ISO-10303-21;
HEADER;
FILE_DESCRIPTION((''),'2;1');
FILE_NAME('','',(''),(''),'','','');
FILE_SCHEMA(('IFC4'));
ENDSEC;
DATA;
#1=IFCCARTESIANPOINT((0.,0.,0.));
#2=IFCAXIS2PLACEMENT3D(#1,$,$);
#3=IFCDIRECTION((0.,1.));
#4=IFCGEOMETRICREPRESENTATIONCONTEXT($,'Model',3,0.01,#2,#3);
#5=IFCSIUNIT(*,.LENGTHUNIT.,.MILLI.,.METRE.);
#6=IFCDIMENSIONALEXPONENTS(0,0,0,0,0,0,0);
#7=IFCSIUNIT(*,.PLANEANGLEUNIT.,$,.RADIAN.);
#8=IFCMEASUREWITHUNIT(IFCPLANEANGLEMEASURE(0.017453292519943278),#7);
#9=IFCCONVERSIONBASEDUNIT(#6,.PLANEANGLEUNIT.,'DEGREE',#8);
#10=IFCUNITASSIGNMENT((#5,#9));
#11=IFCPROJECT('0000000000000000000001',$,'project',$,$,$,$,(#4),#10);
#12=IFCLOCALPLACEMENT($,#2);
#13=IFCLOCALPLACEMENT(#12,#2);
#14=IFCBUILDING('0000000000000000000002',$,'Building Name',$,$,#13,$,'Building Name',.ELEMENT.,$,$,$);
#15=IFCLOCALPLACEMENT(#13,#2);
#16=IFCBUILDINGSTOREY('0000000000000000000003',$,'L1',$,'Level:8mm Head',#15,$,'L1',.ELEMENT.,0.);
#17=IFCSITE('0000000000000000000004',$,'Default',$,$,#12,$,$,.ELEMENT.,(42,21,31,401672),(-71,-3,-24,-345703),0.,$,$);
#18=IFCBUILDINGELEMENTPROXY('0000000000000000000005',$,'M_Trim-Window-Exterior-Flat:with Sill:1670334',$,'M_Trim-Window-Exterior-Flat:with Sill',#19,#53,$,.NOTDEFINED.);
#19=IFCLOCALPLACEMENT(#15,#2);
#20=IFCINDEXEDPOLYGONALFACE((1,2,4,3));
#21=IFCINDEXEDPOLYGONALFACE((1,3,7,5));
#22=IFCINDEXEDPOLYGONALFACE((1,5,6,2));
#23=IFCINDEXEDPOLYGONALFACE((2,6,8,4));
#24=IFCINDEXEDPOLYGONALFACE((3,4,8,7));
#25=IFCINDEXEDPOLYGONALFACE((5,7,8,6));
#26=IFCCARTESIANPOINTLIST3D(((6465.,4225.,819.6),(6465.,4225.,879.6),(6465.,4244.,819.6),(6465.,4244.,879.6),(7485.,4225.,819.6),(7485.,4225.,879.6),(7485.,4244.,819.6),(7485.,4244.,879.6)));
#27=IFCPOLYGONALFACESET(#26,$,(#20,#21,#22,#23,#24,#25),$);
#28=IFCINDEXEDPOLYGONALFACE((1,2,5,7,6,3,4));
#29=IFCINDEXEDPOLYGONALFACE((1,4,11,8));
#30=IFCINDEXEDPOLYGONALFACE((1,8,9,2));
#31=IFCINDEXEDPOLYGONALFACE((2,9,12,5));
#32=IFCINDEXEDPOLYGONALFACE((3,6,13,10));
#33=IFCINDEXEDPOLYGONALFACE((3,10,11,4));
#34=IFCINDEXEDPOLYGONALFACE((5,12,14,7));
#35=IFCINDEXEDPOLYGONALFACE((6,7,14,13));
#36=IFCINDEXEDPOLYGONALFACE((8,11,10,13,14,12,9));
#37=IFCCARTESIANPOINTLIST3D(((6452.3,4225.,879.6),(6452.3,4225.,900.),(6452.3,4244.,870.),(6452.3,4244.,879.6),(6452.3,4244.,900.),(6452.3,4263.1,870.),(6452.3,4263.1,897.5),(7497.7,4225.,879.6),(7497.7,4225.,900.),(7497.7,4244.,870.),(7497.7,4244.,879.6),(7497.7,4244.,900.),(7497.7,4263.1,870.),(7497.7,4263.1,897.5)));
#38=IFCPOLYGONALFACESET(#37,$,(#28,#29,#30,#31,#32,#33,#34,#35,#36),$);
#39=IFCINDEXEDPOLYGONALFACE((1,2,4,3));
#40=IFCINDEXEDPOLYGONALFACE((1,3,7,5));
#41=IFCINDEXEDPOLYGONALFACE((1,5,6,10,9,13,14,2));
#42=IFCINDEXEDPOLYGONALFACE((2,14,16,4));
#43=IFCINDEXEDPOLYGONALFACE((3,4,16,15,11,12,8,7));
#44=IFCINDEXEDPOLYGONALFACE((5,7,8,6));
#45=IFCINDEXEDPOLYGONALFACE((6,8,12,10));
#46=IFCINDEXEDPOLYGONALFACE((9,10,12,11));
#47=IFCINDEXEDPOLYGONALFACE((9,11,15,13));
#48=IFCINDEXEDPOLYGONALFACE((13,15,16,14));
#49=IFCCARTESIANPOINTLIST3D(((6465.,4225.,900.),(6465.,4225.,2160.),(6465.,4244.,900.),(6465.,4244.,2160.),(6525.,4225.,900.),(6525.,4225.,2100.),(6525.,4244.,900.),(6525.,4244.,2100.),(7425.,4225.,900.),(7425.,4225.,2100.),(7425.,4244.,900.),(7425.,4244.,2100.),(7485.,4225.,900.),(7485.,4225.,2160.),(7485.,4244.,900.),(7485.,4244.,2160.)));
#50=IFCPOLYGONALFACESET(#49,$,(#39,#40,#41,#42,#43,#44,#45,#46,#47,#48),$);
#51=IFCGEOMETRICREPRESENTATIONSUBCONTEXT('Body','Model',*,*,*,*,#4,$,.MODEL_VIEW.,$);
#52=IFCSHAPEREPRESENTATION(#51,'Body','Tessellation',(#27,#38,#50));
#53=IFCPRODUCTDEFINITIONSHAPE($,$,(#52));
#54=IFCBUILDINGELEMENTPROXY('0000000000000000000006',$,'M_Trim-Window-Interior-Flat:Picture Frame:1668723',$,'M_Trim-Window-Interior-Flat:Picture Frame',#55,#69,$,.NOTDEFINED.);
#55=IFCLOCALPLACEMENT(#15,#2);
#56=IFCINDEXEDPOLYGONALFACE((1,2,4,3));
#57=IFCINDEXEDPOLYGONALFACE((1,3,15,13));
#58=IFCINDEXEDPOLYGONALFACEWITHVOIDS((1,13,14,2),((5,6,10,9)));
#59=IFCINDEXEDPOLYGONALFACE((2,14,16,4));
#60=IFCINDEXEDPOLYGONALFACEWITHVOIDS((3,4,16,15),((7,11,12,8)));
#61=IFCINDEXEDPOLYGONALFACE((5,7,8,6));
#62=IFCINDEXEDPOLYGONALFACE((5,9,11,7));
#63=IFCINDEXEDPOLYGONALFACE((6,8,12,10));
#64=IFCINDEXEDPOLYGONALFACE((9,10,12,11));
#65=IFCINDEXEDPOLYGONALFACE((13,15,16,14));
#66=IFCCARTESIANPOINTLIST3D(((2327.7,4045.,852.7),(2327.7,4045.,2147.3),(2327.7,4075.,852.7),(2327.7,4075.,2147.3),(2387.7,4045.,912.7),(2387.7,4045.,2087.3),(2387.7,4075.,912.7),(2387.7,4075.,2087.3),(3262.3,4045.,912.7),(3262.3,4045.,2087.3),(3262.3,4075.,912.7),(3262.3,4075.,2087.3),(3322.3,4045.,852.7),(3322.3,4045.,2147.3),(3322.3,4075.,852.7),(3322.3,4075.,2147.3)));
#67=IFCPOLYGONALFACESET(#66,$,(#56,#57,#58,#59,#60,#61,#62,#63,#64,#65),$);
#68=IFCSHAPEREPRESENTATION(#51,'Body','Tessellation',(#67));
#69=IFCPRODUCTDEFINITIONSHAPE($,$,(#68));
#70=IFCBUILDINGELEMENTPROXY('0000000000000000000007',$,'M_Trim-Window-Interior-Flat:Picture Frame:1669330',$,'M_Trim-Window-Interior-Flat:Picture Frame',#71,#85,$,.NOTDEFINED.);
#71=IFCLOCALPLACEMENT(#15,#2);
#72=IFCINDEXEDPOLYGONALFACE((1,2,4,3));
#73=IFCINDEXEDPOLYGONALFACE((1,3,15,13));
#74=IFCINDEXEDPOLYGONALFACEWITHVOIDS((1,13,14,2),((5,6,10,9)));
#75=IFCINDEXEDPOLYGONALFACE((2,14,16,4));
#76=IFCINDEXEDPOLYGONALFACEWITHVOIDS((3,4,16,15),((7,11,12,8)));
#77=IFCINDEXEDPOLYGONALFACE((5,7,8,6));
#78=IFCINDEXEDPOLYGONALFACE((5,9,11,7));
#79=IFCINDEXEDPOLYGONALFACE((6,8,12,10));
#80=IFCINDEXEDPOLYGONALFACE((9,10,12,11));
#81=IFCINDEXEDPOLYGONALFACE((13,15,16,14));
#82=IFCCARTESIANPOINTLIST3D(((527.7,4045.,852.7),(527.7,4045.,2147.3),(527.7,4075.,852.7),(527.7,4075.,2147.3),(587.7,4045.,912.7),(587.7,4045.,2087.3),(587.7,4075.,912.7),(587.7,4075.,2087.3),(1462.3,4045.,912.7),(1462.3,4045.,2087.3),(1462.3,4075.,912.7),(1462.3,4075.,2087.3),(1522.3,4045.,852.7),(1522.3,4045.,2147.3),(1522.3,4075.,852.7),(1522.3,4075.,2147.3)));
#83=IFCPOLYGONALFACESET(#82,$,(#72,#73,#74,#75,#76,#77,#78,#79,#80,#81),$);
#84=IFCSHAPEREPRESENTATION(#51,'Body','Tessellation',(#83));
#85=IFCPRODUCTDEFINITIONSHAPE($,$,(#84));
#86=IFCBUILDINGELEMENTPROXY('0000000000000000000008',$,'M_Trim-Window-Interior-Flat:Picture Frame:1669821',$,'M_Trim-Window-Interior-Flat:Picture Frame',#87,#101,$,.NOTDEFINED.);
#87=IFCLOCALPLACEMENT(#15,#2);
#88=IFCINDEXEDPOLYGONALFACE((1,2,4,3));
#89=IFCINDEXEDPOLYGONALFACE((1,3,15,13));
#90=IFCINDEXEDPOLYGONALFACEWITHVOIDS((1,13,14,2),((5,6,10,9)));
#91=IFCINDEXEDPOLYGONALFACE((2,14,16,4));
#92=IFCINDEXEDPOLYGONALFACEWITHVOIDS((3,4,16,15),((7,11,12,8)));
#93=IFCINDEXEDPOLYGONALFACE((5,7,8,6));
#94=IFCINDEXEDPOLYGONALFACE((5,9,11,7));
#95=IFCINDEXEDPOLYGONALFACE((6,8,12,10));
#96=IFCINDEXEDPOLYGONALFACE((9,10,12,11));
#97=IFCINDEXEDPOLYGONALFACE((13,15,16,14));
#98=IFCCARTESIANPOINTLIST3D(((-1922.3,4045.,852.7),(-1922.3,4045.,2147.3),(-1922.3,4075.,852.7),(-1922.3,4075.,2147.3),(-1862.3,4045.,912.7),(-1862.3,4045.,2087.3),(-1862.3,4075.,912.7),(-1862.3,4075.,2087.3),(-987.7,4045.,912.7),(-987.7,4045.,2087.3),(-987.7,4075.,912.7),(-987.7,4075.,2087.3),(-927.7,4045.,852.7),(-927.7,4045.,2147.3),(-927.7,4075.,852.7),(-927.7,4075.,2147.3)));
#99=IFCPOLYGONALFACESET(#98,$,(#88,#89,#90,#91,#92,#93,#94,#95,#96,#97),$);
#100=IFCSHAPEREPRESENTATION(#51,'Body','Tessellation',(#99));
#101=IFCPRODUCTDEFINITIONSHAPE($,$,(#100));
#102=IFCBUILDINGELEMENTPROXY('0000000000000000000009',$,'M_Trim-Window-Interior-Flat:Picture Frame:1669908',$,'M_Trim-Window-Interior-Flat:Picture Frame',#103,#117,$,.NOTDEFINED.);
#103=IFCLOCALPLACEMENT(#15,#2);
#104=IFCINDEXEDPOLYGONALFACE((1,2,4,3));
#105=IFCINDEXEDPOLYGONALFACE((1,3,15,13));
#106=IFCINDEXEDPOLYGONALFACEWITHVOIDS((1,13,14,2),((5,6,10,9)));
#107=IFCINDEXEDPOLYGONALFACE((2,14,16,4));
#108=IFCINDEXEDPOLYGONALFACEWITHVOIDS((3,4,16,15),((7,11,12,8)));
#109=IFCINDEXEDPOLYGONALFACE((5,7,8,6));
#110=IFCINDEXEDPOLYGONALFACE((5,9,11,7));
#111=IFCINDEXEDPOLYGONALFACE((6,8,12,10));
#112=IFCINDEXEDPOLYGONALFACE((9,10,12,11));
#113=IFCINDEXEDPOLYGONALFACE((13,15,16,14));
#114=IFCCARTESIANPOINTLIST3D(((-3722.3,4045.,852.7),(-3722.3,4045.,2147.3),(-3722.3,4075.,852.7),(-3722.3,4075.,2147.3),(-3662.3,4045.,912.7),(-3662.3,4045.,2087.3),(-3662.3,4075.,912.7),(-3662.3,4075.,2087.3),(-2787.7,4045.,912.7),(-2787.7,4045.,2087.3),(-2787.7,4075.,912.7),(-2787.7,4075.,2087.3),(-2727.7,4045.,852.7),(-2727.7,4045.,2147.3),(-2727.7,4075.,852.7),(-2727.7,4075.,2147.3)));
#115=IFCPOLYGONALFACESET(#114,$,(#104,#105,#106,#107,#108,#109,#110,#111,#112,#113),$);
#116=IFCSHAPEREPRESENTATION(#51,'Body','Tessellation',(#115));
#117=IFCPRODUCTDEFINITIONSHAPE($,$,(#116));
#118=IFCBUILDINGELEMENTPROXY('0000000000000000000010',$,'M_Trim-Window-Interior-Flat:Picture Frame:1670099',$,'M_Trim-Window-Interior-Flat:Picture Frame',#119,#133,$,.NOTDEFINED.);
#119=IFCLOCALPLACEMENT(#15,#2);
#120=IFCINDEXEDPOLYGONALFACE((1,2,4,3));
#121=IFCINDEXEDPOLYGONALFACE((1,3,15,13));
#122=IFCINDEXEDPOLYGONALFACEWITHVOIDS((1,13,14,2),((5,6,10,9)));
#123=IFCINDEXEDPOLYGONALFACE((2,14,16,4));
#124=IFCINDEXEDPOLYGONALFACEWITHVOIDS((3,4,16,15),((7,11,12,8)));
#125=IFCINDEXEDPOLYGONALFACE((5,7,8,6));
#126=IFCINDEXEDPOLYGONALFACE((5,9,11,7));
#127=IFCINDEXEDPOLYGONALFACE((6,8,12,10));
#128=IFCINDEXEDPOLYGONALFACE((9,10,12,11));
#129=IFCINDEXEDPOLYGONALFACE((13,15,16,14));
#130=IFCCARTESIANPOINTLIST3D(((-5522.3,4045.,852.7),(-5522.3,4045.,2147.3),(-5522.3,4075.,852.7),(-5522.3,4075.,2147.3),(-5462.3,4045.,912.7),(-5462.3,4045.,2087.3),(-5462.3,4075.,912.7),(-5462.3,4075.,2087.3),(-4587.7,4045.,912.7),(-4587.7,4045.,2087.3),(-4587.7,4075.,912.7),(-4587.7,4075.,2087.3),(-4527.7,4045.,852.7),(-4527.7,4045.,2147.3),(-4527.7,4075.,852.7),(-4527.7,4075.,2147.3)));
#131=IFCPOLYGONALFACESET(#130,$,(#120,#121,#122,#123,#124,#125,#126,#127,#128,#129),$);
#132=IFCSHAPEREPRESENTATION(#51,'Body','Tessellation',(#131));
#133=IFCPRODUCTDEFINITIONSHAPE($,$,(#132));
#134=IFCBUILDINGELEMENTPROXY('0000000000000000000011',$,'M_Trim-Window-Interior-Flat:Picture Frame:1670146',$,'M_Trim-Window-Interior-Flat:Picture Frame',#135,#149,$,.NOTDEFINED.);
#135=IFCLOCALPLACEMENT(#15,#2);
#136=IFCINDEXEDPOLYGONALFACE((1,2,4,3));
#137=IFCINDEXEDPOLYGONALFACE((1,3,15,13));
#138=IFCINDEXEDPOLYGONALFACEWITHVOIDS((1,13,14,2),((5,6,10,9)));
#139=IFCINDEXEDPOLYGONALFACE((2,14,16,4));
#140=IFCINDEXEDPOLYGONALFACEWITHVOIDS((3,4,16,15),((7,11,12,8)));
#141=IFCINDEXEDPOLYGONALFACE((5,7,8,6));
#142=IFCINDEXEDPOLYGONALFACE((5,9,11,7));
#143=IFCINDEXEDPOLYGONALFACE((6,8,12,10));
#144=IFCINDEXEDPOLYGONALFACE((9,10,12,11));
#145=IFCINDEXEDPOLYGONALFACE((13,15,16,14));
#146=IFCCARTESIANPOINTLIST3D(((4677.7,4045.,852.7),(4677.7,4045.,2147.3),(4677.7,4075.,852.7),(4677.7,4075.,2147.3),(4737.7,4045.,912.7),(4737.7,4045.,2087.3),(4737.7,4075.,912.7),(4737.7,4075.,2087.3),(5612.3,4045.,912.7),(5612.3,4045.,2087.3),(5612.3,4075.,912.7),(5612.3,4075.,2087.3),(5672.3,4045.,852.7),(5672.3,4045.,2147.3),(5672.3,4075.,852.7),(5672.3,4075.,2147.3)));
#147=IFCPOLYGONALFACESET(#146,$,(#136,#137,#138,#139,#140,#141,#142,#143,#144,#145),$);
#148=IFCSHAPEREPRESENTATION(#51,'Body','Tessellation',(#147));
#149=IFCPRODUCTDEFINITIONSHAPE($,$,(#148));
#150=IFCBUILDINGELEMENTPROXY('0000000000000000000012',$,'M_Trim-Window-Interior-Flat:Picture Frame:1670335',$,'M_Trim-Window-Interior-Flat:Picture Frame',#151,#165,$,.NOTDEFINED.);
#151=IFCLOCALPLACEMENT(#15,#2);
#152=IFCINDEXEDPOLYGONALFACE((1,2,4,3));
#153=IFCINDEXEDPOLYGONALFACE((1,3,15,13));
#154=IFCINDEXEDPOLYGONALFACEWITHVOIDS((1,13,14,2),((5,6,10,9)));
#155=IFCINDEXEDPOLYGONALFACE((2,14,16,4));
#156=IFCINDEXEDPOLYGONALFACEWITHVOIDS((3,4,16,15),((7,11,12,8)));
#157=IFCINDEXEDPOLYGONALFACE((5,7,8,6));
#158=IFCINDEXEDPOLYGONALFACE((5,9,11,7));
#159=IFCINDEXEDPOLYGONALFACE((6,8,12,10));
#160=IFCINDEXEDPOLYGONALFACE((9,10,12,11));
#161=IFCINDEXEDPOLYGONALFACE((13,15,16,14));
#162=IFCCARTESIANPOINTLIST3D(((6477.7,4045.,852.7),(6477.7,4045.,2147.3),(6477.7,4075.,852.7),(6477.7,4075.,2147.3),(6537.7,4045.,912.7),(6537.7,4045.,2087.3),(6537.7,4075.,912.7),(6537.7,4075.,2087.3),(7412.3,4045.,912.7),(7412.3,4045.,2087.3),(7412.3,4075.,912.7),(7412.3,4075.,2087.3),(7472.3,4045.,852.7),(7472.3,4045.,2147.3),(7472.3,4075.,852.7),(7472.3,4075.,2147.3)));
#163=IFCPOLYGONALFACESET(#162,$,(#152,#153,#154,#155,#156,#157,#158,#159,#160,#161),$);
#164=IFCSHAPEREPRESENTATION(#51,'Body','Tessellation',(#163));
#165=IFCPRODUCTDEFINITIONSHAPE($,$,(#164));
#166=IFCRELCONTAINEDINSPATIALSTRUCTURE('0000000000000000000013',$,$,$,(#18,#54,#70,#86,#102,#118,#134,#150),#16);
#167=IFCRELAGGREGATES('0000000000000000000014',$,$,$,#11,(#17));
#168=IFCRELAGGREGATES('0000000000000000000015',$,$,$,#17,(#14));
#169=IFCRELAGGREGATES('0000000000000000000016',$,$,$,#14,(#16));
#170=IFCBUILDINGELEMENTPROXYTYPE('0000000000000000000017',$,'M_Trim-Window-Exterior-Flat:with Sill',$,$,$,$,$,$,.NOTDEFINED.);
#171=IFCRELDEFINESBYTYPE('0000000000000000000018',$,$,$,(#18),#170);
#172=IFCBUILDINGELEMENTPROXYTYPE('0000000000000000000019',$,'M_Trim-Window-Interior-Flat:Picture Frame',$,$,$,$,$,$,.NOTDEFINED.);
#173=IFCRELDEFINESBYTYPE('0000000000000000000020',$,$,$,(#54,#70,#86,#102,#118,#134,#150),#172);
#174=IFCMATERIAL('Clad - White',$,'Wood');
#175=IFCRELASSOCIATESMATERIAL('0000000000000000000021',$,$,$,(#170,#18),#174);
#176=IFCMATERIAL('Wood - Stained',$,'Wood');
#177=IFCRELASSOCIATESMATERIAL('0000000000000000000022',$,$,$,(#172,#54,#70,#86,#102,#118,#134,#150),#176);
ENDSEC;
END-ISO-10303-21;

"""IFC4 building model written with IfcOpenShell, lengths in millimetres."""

from ifc_helpers import new_model, entity, si_unit, converted_unit, direction, frame, frame_2d, origin, place, context, subcontext, project, spatial, polyline, rectangle, outline, extrude, source, transform, mapped, material, type_object, type_shapes, element, save


model = new_model("IFC4")

# Units and contexts
model_context = context("Model", 3, precision=0.01, world=origin(), true_north=direction((0.0, 1.0)))
body_context = subcontext(model_context, "Body", "Model", "MODEL_VIEW")
ifc_project = project(units=[si_unit("LENGTHUNIT", "METRE", prefix="MILLI"), converted_unit("PLANEANGLEUNIT", "DEGREE", entity("IfcPlaneAngleMeasure", 0.017453292519943278), si_unit("PLANEANGLEUNIT", "RADIAN"), dimensions=[0, 0, 0, 0, 0, 0, 0])], contexts=[model_context])

# Site, building, storey
site_placement = place(None, origin())
site = spatial("IfcSite", under=ifc_project, at=site_placement, Name="Default", CompositionType="ELEMENT", RefLatitude=(42, 21, 31, 401672), RefLongitude=(-71, -3, -24, -345703), RefElevation=0.0)
building_placement = place(site_placement, origin())
building = spatial("IfcBuilding", under=site, at=building_placement, Name="Building Name", LongName="Building Name", CompositionType="ELEMENT")
storey_placement = place(building_placement, origin())
storey = spatial("IfcBuildingStorey", under=building, at=storey_placement, Name="L1", ObjectType="Level:8mm Head", LongName="L1", CompositionType="ELEMENT", Elevation=0.0)

# Building element proxies
ifc_material_1 = material(Name="Clad - White", Category="Wood")
ifc_material_2 = material(Name="Wood - Stained", Category="Wood")
building_element_proxy_type_1 = type_object("IfcBuildingElementProxyType", Name="M_Trim-Window-Exterior-Flat:with Sill", PredefinedType="NOTDEFINED", material=ifc_material_1)
shared_shape_1 = source(origin(), body_context, "Body", "SweptSolid", [
    extrude(rectangle(XDim=1020.0, YDim=60.0, at=frame_2d((0.0, 0.0), x_axis=(1.0, 0.0))), frame((0.0, -1250.4, 0.0), z_axis=(0.0, 0.0, 1.0), x_axis=(-1.0, 0.0, 0.0)), (0.0, 0.0, 1.0), 19.0),
    extrude(outline(polyline([(-19.0, -15.2), (0.0, -15.2), (0.0, -5.7), (19.0, -5.7), (19.0, 14.8), (0.0, 14.8), (-19.0, 12.3), (-19.0, -15.2)])), frame((-522.7, -1214.8, 19.0), z_axis=(1.0, 0.0, 0.0), x_axis=(0.0, 0.0, -1.0)), (0.0, 0.0, 1.0), 1045.4),
    extrude(outline(polyline([(-645.0, -510.0), (615.0, -510.0), (615.0, -450.0), (-585.0, -450.0), (-585.0, 450.0), (615.0, 450.0), (615.0, 510.0), (-645.0, 510.0), (-645.0, -510.0)])), frame((0.0, -585.0, 0.0), z_axis=(0.0, 0.0, 1.0), x_axis=(0.0, -1.0, 0.0)), (0.0, 0.0, 1.0), 19.0),
])
type_shapes(building_element_proxy_type_1, [shared_shape_1])
for number, where, z_axis, x_axis, name in (
    (1, (6975.0, 4225.0, 2100.0), (0.0, 1.0, 0.0), (-1.0, 0.0, 0.0), "M_Trim-Window-Exterior-Flat:with Sill:1670334"),
):
    element("IfcBuildingElementProxy", number, at=place(storey_placement, frame(where, z_axis=z_axis, x_axis=x_axis)), inside=storey, type_object=building_element_proxy_type_1, material=ifc_material_1, Name=name, ObjectType="M_Trim-Window-Exterior-Flat:with Sill", PredefinedType="NOTDEFINED", context=body_context, shape_type="MappedRepresentation", body=[
        mapped(shared_shape_1, transform((0.0, 0.0, 0.0), scale=1.0)),
    ])
building_element_proxy_type_2 = type_object("IfcBuildingElementProxyType", Name="M_Trim-Window-Interior-Flat:Picture Frame", PredefinedType="NOTDEFINED", material=ifc_material_2)
shared_shape_2 = source(origin(), body_context, "Body", "SweptSolid", [
    extrude(outline(polyline([(-497.3, -647.3), (497.3, -647.3), (497.3, 647.3), (-497.3, 647.3), (-497.3, -647.3)]), holes=[polyline([(-437.3, -587.3), (-437.3, 587.3), (437.3, 587.3), (437.3, -587.3), (-437.3, -587.3)])]), frame((0.0, -600.0, 0.0), z_axis=(0.0, 0.0, 1.0), x_axis=(-1.0, 0.0, 0.0)), (0.0, 0.0, 1.0), 30.0),
])
type_shapes(building_element_proxy_type_2, [shared_shape_2])
for number, where, z_axis, x_axis, name in (
    (2, (2825.0, 4075.0, 2100.0), (0.0, -1.0, 0.0), (1.0, 0.0, 0.0), "M_Trim-Window-Interior-Flat:Picture Frame:1668723"),
    (3, (1025.0, 4075.0, 2100.0), (0.0, -1.0, 0.0), (1.0, 0.0, 0.0), "M_Trim-Window-Interior-Flat:Picture Frame:1669330"),
    (4, (-1425.0, 4075.0, 2100.0), (0.0, -1.0, 0.0), (1.0, 0.0, 0.0), "M_Trim-Window-Interior-Flat:Picture Frame:1669821"),
    (5, (-3225.0, 4075.0, 2100.0), (0.0, -1.0, 0.0), (1.0, 0.0, 0.0), "M_Trim-Window-Interior-Flat:Picture Frame:1669908"),
    (6, (-5025.0, 4075.0, 2100.0), (0.0, -1.0, 0.0), (1.0, 0.0, 0.0), "M_Trim-Window-Interior-Flat:Picture Frame:1670099"),
    (7, (5175.0, 4075.0, 2100.0), (0.0, -1.0, 0.0), (1.0, 0.0, 0.0), "M_Trim-Window-Interior-Flat:Picture Frame:1670146"),
    (8, (6975.0, 4075.0, 2100.0), (0.0, -1.0, 0.0), (1.0, 0.0, 0.0), "M_Trim-Window-Interior-Flat:Picture Frame:1670335"),
):
    element("IfcBuildingElementProxy", number, at=place(storey_placement, frame(where, z_axis=z_axis, x_axis=x_axis)), inside=storey, type_object=building_element_proxy_type_2, material=ifc_material_2, Name=name, ObjectType="M_Trim-Window-Interior-Flat:Picture Frame", PredefinedType="NOTDEFINED", context=body_context, shape_type="MappedRepresentation", body=[
        mapped(shared_shape_2, transform((0.0, 0.0, 0.0), scale=1.0)),
    ])

save(model, "model.ifc")
